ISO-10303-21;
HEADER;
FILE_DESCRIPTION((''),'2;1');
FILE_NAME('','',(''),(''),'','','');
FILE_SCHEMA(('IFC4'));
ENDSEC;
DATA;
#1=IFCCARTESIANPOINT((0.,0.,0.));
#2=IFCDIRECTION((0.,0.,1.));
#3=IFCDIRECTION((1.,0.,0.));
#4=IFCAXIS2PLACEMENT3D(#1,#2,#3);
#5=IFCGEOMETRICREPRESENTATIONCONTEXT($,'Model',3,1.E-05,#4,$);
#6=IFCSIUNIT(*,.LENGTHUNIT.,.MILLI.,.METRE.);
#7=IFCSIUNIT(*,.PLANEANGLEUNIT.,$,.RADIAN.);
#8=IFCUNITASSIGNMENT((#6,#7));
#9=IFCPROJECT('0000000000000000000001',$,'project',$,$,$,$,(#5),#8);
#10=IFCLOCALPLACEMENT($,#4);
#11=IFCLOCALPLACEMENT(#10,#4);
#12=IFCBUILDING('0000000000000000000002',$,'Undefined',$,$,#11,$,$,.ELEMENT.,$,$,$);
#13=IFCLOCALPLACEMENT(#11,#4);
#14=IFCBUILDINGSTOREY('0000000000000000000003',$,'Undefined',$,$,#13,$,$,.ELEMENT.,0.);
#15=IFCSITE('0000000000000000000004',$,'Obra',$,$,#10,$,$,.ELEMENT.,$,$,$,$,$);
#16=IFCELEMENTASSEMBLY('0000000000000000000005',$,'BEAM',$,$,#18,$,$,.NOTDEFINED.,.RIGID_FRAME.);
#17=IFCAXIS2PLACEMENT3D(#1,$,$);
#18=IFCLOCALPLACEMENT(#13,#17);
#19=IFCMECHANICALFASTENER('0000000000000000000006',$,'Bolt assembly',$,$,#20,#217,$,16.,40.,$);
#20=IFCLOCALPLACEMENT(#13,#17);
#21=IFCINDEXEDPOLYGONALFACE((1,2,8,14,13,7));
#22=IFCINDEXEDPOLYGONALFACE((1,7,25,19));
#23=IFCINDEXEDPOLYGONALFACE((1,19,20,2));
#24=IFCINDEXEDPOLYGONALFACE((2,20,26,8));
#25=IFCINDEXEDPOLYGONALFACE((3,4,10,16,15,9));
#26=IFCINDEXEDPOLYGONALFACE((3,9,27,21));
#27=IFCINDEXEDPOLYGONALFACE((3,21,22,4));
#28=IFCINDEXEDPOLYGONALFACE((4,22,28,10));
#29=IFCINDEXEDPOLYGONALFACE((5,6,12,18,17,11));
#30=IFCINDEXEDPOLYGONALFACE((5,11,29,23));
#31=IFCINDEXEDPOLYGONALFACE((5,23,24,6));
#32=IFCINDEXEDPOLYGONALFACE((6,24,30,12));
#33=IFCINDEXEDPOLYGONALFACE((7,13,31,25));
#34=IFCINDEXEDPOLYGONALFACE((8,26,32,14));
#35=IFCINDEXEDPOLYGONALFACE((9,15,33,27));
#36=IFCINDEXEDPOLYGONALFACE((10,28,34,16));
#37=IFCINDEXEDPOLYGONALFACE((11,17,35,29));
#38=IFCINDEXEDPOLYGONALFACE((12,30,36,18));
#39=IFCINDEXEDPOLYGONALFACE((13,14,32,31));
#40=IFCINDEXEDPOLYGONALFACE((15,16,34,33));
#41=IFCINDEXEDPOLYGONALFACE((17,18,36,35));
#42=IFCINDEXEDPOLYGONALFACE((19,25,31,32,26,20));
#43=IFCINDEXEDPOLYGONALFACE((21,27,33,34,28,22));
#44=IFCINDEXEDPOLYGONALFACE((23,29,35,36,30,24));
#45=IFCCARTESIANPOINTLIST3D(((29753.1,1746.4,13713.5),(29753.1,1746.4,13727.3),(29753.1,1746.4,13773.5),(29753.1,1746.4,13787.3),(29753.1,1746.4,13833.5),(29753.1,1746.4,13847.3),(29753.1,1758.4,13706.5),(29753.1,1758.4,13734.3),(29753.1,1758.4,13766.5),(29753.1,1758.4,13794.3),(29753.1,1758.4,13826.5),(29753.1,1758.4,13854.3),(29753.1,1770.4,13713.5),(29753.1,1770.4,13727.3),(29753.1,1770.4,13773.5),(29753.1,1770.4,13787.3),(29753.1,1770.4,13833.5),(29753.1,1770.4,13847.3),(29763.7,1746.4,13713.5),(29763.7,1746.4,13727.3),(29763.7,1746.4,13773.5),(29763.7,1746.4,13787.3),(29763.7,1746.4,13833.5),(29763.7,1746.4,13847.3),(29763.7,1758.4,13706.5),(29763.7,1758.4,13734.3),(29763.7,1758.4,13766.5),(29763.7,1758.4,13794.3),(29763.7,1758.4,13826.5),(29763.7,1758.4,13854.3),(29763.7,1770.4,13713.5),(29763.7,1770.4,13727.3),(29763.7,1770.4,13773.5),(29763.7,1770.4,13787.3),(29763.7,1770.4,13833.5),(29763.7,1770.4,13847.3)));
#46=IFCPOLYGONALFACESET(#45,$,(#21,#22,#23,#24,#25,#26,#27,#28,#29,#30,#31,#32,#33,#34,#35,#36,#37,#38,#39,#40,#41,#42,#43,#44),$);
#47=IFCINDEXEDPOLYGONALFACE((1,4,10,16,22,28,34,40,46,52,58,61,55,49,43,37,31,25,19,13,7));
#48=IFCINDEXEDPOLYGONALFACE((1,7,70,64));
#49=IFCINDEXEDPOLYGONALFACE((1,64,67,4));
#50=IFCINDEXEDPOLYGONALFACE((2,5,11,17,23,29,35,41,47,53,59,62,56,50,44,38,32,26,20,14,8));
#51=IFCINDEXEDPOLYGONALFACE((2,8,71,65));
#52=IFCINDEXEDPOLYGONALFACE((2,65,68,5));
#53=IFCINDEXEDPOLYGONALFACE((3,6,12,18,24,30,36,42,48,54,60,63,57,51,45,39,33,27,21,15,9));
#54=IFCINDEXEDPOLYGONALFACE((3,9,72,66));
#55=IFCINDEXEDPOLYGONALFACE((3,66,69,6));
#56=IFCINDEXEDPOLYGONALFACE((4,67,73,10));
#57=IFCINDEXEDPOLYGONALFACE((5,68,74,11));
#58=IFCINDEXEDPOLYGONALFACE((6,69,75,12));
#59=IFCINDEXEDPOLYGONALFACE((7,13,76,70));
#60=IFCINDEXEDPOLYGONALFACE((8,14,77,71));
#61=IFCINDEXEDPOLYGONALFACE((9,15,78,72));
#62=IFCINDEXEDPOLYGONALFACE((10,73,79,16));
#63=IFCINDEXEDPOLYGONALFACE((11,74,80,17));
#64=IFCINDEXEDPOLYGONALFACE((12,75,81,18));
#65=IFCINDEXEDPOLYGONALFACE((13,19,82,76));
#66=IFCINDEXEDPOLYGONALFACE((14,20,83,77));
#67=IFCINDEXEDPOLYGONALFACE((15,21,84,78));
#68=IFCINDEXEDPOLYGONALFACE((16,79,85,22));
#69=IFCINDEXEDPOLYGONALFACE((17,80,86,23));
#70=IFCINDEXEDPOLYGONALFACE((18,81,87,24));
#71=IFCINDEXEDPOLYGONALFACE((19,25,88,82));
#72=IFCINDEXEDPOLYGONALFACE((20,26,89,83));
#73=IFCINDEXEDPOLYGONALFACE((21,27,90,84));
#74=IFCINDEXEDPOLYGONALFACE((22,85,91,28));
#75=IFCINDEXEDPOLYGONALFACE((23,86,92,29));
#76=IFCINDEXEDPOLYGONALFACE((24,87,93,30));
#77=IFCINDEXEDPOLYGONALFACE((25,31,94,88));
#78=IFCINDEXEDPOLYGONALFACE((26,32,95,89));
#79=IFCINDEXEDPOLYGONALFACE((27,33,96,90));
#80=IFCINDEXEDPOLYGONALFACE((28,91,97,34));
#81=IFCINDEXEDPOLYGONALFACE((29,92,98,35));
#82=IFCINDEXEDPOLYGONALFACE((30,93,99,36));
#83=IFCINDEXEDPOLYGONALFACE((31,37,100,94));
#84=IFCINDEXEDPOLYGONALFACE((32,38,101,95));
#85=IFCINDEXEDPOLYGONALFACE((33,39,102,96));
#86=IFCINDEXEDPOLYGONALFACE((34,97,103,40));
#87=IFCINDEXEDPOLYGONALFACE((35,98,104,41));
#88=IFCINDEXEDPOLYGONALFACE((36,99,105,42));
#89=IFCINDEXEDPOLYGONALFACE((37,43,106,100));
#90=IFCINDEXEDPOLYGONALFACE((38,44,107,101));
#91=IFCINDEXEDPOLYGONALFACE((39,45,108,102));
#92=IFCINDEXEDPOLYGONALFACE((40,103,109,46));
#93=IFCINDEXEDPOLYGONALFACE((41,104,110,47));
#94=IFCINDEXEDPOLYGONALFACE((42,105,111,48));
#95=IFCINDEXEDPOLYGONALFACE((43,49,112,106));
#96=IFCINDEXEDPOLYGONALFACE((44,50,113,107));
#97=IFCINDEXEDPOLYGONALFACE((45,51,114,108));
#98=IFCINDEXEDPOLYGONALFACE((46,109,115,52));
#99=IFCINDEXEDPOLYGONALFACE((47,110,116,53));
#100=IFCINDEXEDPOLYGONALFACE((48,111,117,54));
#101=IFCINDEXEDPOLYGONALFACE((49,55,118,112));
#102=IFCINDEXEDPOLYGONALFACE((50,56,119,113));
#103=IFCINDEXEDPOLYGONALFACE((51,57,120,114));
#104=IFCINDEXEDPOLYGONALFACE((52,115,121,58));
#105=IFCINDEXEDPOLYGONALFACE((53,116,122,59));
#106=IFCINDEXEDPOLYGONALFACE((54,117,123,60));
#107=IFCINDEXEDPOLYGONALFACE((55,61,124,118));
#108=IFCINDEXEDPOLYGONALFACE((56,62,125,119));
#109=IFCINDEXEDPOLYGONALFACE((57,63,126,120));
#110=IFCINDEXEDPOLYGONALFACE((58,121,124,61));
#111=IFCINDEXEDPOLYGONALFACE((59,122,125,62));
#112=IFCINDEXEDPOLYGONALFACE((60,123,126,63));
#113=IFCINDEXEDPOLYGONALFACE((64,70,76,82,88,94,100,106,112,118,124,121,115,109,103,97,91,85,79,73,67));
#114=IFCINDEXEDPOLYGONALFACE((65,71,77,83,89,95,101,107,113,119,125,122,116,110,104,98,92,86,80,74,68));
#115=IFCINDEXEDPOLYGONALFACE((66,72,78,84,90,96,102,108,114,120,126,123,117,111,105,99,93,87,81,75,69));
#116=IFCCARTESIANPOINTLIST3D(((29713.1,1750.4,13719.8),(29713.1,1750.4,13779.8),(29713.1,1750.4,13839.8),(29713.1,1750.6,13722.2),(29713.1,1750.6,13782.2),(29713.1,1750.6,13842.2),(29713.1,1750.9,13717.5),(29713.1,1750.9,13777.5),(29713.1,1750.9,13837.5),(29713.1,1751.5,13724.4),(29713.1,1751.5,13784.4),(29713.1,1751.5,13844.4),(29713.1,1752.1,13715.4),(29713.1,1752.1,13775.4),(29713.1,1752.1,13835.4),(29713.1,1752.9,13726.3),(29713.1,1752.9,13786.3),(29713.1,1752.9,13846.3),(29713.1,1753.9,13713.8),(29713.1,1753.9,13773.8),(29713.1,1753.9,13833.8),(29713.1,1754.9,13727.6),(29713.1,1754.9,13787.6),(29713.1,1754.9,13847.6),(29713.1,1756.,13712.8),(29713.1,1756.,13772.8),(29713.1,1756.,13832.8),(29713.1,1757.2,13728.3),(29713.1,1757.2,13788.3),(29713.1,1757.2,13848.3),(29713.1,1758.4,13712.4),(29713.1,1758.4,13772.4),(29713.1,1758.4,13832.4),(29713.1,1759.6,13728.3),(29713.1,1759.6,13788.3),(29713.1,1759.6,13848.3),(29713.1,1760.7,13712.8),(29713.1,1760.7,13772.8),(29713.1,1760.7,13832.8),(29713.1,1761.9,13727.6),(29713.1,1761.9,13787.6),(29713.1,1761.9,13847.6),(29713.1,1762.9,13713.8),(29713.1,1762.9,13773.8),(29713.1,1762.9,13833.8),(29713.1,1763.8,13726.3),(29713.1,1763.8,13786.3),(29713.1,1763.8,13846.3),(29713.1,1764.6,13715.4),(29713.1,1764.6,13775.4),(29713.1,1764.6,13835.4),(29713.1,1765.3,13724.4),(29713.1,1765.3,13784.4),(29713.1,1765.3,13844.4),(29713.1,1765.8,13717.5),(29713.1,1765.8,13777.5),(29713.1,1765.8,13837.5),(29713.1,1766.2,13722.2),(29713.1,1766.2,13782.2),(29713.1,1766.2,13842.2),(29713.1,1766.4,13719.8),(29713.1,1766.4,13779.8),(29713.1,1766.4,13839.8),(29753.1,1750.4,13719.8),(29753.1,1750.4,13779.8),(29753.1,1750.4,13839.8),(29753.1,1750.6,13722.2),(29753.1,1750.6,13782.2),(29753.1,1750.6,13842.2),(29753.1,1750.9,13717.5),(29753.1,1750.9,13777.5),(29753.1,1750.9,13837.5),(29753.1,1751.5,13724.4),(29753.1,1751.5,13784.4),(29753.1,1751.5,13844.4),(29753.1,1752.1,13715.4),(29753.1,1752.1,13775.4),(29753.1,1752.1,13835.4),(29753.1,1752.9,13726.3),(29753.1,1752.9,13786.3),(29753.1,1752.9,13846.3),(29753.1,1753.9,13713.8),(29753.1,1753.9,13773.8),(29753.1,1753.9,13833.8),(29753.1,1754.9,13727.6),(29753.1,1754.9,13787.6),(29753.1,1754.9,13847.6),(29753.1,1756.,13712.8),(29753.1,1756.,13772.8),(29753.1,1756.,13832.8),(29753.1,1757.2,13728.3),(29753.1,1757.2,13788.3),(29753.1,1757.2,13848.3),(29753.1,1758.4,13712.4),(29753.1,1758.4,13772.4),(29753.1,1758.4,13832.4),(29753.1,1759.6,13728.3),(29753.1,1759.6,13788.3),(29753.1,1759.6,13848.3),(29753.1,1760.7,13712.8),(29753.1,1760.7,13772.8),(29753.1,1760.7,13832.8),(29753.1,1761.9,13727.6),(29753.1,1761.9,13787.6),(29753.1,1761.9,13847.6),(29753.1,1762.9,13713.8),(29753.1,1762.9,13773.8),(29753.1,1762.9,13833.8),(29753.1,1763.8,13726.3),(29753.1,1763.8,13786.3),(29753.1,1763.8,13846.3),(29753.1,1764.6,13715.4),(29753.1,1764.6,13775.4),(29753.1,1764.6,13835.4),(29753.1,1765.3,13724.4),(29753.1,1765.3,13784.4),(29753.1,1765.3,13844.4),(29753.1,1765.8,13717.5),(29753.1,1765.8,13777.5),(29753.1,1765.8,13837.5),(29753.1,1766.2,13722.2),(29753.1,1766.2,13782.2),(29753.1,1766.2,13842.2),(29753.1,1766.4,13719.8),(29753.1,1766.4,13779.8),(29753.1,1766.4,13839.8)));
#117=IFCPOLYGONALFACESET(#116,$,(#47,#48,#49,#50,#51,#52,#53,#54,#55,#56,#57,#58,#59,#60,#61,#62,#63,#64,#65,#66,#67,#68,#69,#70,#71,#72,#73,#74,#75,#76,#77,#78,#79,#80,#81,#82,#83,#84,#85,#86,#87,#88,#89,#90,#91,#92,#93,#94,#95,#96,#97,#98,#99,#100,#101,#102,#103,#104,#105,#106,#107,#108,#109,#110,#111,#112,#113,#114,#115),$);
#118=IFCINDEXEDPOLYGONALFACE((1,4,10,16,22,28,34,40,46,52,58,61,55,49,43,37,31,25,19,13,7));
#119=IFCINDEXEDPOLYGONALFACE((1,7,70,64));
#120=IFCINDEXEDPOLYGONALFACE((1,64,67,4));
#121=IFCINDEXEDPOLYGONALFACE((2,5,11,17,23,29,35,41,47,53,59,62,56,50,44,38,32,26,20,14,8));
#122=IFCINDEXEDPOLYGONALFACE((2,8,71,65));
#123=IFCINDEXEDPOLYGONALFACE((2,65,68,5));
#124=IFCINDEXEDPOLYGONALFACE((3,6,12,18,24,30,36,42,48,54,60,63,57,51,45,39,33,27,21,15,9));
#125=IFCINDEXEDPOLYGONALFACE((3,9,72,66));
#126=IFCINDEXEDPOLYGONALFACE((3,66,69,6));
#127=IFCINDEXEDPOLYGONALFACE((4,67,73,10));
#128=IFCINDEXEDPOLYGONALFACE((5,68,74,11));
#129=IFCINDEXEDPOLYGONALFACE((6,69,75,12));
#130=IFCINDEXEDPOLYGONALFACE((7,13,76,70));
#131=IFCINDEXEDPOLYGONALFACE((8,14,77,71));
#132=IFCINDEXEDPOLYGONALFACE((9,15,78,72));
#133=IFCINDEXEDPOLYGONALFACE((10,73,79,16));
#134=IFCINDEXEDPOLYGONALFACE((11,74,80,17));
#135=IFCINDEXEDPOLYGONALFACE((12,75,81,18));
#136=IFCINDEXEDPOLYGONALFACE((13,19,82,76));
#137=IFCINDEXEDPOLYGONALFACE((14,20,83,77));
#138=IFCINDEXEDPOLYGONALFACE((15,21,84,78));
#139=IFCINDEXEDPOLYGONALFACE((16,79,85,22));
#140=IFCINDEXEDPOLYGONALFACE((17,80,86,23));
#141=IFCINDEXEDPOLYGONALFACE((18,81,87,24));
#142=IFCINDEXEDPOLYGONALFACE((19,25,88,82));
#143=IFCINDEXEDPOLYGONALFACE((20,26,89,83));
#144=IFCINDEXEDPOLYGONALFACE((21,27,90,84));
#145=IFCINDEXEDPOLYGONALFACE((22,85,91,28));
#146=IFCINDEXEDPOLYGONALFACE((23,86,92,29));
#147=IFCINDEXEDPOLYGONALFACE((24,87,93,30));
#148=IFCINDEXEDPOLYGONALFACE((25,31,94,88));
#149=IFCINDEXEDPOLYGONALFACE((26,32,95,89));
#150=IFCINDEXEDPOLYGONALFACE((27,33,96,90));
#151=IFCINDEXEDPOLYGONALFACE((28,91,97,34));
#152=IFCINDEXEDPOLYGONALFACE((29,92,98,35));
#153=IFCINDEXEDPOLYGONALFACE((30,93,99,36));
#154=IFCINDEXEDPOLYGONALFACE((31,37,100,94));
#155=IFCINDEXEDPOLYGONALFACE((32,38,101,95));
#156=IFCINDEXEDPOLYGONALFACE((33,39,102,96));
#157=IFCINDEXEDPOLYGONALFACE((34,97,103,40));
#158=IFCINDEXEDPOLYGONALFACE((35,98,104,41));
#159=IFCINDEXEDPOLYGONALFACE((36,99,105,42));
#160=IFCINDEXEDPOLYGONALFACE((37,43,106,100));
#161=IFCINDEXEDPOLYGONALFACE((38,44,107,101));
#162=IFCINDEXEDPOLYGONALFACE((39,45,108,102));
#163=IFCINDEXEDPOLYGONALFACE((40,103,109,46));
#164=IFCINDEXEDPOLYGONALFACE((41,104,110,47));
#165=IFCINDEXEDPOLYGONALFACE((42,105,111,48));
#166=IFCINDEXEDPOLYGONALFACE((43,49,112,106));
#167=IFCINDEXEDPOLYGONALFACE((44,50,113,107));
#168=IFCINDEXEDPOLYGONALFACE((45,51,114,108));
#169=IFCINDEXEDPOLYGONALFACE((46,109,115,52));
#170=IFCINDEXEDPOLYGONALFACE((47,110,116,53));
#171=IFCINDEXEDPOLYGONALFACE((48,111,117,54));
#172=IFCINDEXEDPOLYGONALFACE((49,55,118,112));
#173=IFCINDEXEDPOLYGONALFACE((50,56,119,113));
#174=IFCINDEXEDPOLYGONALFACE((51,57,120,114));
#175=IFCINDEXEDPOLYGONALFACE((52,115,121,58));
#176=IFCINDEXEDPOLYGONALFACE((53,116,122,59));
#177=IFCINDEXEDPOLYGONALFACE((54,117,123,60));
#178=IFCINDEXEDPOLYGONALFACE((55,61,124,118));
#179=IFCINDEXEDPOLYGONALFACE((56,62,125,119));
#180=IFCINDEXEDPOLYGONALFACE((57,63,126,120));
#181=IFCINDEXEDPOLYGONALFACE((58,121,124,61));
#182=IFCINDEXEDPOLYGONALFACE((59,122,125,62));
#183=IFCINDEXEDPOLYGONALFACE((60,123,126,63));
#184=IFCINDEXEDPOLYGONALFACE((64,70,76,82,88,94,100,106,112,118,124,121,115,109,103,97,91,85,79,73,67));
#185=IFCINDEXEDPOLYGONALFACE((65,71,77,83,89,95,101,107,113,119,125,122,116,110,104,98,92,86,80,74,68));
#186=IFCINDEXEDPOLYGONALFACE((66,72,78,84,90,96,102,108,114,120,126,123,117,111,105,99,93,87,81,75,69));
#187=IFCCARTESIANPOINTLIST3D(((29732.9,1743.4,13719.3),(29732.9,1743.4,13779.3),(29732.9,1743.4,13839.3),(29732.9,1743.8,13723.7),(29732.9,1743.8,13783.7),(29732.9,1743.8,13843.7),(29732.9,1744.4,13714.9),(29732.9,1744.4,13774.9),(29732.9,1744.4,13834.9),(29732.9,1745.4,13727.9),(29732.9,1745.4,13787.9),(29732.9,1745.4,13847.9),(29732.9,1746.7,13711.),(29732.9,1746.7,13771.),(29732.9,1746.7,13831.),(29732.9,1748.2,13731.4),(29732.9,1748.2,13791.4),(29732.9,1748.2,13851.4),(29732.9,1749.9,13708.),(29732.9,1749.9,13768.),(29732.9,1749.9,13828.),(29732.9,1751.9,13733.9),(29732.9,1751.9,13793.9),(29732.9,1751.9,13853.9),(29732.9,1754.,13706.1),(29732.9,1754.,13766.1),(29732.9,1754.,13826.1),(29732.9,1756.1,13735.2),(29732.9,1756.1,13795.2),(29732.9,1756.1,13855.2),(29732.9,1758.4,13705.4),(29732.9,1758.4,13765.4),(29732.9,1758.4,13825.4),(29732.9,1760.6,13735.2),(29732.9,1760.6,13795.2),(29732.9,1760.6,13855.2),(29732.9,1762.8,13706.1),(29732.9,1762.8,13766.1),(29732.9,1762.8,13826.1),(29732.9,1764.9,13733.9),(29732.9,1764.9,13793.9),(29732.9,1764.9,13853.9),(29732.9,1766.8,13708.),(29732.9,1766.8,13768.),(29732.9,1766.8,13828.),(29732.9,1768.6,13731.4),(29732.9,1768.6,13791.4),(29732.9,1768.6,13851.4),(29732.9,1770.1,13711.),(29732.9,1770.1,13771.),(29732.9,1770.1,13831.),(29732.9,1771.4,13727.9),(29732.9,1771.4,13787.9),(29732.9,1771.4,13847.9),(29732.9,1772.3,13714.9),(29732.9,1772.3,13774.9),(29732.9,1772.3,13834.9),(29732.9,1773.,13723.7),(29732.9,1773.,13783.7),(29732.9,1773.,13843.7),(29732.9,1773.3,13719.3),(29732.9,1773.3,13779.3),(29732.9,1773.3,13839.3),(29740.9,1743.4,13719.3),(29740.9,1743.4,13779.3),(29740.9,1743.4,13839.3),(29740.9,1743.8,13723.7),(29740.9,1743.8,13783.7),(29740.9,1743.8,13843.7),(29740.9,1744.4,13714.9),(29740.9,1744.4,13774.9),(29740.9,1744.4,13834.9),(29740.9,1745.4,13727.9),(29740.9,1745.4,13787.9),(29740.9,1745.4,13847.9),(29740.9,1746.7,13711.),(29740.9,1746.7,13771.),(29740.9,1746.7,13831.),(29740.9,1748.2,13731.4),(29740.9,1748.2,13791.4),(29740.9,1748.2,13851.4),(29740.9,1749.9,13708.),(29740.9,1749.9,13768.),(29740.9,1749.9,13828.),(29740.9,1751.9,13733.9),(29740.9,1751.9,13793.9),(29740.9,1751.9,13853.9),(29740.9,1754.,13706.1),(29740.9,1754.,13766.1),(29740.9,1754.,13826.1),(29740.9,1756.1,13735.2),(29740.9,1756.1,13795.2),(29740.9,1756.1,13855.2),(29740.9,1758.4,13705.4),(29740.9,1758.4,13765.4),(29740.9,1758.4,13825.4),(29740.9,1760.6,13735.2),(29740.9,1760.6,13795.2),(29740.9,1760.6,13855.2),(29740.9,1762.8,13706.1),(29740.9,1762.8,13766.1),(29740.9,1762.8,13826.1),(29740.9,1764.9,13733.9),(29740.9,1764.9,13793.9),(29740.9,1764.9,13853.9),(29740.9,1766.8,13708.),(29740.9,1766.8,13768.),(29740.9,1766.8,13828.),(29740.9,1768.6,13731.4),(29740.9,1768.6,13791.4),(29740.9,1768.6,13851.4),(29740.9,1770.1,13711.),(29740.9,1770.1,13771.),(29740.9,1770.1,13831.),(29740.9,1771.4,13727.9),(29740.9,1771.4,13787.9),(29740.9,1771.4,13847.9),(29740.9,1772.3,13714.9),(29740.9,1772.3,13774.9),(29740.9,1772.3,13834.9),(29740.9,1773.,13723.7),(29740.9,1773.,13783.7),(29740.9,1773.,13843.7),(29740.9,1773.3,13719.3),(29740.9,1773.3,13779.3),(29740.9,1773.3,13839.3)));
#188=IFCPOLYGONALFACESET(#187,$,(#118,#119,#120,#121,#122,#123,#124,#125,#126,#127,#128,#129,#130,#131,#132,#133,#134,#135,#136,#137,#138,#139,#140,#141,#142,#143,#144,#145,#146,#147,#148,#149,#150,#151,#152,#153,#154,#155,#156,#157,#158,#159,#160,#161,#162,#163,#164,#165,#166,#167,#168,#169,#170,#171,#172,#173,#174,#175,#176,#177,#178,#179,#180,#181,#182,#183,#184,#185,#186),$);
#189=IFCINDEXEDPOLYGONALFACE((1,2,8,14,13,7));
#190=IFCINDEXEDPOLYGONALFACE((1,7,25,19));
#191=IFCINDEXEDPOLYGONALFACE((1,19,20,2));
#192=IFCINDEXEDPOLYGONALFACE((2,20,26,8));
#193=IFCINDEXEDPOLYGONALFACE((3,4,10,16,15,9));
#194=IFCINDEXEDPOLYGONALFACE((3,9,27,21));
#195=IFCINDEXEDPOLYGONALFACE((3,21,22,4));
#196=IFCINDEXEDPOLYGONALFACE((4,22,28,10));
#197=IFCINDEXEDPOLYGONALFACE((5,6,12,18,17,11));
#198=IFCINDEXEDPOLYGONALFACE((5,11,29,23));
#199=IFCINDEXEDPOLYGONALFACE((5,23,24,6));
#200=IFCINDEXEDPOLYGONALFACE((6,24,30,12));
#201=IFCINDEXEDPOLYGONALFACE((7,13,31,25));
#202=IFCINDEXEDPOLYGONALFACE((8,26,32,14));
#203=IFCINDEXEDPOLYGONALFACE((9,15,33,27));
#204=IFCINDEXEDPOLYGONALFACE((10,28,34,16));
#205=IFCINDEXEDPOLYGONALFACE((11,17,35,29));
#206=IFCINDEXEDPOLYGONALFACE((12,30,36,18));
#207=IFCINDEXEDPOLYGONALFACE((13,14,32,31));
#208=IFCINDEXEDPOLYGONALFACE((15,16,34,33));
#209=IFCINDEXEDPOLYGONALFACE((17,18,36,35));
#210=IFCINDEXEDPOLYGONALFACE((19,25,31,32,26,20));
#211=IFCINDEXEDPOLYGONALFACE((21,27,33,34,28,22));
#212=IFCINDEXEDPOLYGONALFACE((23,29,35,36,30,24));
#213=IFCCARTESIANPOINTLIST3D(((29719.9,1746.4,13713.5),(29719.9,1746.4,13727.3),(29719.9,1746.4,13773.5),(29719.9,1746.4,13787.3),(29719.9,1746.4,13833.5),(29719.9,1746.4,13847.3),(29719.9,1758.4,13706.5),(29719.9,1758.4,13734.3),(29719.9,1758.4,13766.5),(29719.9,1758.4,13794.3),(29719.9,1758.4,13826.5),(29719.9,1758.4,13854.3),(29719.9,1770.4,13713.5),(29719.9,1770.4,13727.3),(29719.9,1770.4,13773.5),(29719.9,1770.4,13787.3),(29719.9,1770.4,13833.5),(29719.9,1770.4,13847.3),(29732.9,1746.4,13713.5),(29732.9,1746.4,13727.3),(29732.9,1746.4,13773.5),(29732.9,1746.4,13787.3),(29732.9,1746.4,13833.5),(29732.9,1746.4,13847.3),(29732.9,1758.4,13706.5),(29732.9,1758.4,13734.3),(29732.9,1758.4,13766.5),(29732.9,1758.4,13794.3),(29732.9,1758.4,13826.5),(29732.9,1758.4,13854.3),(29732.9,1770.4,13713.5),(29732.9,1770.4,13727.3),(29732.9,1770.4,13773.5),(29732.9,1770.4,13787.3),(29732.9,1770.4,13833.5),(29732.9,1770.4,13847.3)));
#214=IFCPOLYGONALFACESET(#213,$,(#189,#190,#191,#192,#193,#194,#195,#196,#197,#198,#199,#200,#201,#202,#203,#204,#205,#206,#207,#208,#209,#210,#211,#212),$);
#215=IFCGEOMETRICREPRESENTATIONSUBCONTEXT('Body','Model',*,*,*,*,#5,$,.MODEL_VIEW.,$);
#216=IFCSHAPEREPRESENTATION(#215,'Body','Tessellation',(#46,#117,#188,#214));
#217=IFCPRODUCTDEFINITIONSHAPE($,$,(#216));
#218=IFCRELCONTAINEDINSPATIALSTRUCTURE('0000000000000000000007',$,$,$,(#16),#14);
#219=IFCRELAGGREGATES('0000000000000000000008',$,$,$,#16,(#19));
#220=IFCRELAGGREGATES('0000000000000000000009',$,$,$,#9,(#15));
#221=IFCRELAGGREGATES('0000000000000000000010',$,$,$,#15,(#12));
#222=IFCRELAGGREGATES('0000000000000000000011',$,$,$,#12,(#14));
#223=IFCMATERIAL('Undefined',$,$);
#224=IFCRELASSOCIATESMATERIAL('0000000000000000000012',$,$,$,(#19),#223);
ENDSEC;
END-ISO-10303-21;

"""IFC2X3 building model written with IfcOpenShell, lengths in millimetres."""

from ifc_helpers import new_model, si_unit, frame, origin_with_axes, origin_2d_with_axis, place, context, subcontext, project, spatial, polyline, circle, outline, extrude, source, transform, mapped, material, element, aggregate, save


model = new_model("IFC2X3")

# Units and contexts
model_context = context("Model", 3, precision=1e-05, world=origin_with_axes())
body_context = subcontext(model_context, "Body", "Model", "MODEL_VIEW")
ifc_project = project(units=[si_unit("LENGTHUNIT", "METRE", prefix="MILLI"), si_unit("PLANEANGLEUNIT", "RADIAN")], contexts=[model_context])

# Site, building, storey
site_placement = place(None, origin_with_axes())
site = spatial("IfcSite", under=ifc_project, at=site_placement, Name="Obra", CompositionType="ELEMENT")
building_placement = place(site_placement, origin_with_axes())
building = spatial("IfcBuilding", under=site, at=building_placement, Name="Undefined", CompositionType="ELEMENT")
storey_placement = place(building_placement, origin_with_axes())
storey = spatial("IfcBuildingStorey", under=building, at=storey_placement, Name="Undefined", CompositionType="ELEMENT", Elevation=0.0)

# Shared definitions
ifc_material_1 = material(Name="Undefined")

# Element assembly, mechanical fastener
shared_shape_1 = source(origin_with_axes(), body_context, "Body", "SweptSolid", [
    extrude(outline(polyline([(13.9, 0.0), (6.9, 12.0), (-6.9, 12.0), (-13.9, 0.0), (-6.9, -12.0), (6.9, -12.0), (13.9, 0.0)])), frame((0.0, -13.7, 0.0), z_axis=(0.0, 1.0, 0.0), x_axis=(1.0, 0.0, 0.0)), (0.0, 0.0, 1.0), 10.6),
    extrude(circle(Radius=8.0, at=origin_2d_with_axis()), frame((0.0, -3.1, 0.0), z_axis=(0.0, 1.0, 0.0), x_axis=(1.0, 0.0, 0.0)), (0.0, 0.0, 1.0), 40.0),
    extrude(circle(Radius=15.0, at=origin_2d_with_axis()), frame((0.0, 9.1, 0.0), z_axis=(0.0, 1.0, 0.0), x_axis=(1.0, 0.0, 0.0)), (0.0, 0.0, 1.0), 8.0),
    extrude(outline(polyline([(13.9, 0.0), (6.9, 12.0), (-6.9, 12.0), (-13.9, 0.0), (-6.9, -12.0), (6.9, -12.0), (13.9, 0.0)])), frame((0.0, 17.1, 0.0), z_axis=(0.0, 1.0, 0.0), x_axis=(1.0, 0.0, 0.0)), (0.0, 0.0, 1.0), 13.0),
])
assembly_1_placement = place(storey_placement, origin_with_axes())
assembly_1 = element("IfcElementAssembly", 1, at=assembly_1_placement, inside=storey, Name="BEAM", AssemblyPlace="NOTDEFINED", PredefinedType="RIGID_FRAME")
mechanical_fastener_1_placement = place(assembly_1_placement, frame((29750.0, 1708.4, 13875.4), z_axis=(0.0, 1.0, 0.0), x_axis=(0.0, 0.0, -1.0)))
mechanical_fastener_1 = element("IfcMechanicalFastener", 2, at=mechanical_fastener_1_placement, material=ifc_material_1, Name="Bolt assembly", NominalDiameter=16.0, NominalLength=40.0, context=body_context, shape_type="MappedRepresentation", body=[
    mapped(shared_shape_1, transform((35.0, 0.0, 50.0))),
    mapped(shared_shape_1, transform((95.0, 0.0, 50.0))),
    mapped(shared_shape_1, transform((155.0, 0.0, 50.0))),
])
aggregate(assembly_1, [mechanical_fastener_1])

save(model, "model.ifc")
